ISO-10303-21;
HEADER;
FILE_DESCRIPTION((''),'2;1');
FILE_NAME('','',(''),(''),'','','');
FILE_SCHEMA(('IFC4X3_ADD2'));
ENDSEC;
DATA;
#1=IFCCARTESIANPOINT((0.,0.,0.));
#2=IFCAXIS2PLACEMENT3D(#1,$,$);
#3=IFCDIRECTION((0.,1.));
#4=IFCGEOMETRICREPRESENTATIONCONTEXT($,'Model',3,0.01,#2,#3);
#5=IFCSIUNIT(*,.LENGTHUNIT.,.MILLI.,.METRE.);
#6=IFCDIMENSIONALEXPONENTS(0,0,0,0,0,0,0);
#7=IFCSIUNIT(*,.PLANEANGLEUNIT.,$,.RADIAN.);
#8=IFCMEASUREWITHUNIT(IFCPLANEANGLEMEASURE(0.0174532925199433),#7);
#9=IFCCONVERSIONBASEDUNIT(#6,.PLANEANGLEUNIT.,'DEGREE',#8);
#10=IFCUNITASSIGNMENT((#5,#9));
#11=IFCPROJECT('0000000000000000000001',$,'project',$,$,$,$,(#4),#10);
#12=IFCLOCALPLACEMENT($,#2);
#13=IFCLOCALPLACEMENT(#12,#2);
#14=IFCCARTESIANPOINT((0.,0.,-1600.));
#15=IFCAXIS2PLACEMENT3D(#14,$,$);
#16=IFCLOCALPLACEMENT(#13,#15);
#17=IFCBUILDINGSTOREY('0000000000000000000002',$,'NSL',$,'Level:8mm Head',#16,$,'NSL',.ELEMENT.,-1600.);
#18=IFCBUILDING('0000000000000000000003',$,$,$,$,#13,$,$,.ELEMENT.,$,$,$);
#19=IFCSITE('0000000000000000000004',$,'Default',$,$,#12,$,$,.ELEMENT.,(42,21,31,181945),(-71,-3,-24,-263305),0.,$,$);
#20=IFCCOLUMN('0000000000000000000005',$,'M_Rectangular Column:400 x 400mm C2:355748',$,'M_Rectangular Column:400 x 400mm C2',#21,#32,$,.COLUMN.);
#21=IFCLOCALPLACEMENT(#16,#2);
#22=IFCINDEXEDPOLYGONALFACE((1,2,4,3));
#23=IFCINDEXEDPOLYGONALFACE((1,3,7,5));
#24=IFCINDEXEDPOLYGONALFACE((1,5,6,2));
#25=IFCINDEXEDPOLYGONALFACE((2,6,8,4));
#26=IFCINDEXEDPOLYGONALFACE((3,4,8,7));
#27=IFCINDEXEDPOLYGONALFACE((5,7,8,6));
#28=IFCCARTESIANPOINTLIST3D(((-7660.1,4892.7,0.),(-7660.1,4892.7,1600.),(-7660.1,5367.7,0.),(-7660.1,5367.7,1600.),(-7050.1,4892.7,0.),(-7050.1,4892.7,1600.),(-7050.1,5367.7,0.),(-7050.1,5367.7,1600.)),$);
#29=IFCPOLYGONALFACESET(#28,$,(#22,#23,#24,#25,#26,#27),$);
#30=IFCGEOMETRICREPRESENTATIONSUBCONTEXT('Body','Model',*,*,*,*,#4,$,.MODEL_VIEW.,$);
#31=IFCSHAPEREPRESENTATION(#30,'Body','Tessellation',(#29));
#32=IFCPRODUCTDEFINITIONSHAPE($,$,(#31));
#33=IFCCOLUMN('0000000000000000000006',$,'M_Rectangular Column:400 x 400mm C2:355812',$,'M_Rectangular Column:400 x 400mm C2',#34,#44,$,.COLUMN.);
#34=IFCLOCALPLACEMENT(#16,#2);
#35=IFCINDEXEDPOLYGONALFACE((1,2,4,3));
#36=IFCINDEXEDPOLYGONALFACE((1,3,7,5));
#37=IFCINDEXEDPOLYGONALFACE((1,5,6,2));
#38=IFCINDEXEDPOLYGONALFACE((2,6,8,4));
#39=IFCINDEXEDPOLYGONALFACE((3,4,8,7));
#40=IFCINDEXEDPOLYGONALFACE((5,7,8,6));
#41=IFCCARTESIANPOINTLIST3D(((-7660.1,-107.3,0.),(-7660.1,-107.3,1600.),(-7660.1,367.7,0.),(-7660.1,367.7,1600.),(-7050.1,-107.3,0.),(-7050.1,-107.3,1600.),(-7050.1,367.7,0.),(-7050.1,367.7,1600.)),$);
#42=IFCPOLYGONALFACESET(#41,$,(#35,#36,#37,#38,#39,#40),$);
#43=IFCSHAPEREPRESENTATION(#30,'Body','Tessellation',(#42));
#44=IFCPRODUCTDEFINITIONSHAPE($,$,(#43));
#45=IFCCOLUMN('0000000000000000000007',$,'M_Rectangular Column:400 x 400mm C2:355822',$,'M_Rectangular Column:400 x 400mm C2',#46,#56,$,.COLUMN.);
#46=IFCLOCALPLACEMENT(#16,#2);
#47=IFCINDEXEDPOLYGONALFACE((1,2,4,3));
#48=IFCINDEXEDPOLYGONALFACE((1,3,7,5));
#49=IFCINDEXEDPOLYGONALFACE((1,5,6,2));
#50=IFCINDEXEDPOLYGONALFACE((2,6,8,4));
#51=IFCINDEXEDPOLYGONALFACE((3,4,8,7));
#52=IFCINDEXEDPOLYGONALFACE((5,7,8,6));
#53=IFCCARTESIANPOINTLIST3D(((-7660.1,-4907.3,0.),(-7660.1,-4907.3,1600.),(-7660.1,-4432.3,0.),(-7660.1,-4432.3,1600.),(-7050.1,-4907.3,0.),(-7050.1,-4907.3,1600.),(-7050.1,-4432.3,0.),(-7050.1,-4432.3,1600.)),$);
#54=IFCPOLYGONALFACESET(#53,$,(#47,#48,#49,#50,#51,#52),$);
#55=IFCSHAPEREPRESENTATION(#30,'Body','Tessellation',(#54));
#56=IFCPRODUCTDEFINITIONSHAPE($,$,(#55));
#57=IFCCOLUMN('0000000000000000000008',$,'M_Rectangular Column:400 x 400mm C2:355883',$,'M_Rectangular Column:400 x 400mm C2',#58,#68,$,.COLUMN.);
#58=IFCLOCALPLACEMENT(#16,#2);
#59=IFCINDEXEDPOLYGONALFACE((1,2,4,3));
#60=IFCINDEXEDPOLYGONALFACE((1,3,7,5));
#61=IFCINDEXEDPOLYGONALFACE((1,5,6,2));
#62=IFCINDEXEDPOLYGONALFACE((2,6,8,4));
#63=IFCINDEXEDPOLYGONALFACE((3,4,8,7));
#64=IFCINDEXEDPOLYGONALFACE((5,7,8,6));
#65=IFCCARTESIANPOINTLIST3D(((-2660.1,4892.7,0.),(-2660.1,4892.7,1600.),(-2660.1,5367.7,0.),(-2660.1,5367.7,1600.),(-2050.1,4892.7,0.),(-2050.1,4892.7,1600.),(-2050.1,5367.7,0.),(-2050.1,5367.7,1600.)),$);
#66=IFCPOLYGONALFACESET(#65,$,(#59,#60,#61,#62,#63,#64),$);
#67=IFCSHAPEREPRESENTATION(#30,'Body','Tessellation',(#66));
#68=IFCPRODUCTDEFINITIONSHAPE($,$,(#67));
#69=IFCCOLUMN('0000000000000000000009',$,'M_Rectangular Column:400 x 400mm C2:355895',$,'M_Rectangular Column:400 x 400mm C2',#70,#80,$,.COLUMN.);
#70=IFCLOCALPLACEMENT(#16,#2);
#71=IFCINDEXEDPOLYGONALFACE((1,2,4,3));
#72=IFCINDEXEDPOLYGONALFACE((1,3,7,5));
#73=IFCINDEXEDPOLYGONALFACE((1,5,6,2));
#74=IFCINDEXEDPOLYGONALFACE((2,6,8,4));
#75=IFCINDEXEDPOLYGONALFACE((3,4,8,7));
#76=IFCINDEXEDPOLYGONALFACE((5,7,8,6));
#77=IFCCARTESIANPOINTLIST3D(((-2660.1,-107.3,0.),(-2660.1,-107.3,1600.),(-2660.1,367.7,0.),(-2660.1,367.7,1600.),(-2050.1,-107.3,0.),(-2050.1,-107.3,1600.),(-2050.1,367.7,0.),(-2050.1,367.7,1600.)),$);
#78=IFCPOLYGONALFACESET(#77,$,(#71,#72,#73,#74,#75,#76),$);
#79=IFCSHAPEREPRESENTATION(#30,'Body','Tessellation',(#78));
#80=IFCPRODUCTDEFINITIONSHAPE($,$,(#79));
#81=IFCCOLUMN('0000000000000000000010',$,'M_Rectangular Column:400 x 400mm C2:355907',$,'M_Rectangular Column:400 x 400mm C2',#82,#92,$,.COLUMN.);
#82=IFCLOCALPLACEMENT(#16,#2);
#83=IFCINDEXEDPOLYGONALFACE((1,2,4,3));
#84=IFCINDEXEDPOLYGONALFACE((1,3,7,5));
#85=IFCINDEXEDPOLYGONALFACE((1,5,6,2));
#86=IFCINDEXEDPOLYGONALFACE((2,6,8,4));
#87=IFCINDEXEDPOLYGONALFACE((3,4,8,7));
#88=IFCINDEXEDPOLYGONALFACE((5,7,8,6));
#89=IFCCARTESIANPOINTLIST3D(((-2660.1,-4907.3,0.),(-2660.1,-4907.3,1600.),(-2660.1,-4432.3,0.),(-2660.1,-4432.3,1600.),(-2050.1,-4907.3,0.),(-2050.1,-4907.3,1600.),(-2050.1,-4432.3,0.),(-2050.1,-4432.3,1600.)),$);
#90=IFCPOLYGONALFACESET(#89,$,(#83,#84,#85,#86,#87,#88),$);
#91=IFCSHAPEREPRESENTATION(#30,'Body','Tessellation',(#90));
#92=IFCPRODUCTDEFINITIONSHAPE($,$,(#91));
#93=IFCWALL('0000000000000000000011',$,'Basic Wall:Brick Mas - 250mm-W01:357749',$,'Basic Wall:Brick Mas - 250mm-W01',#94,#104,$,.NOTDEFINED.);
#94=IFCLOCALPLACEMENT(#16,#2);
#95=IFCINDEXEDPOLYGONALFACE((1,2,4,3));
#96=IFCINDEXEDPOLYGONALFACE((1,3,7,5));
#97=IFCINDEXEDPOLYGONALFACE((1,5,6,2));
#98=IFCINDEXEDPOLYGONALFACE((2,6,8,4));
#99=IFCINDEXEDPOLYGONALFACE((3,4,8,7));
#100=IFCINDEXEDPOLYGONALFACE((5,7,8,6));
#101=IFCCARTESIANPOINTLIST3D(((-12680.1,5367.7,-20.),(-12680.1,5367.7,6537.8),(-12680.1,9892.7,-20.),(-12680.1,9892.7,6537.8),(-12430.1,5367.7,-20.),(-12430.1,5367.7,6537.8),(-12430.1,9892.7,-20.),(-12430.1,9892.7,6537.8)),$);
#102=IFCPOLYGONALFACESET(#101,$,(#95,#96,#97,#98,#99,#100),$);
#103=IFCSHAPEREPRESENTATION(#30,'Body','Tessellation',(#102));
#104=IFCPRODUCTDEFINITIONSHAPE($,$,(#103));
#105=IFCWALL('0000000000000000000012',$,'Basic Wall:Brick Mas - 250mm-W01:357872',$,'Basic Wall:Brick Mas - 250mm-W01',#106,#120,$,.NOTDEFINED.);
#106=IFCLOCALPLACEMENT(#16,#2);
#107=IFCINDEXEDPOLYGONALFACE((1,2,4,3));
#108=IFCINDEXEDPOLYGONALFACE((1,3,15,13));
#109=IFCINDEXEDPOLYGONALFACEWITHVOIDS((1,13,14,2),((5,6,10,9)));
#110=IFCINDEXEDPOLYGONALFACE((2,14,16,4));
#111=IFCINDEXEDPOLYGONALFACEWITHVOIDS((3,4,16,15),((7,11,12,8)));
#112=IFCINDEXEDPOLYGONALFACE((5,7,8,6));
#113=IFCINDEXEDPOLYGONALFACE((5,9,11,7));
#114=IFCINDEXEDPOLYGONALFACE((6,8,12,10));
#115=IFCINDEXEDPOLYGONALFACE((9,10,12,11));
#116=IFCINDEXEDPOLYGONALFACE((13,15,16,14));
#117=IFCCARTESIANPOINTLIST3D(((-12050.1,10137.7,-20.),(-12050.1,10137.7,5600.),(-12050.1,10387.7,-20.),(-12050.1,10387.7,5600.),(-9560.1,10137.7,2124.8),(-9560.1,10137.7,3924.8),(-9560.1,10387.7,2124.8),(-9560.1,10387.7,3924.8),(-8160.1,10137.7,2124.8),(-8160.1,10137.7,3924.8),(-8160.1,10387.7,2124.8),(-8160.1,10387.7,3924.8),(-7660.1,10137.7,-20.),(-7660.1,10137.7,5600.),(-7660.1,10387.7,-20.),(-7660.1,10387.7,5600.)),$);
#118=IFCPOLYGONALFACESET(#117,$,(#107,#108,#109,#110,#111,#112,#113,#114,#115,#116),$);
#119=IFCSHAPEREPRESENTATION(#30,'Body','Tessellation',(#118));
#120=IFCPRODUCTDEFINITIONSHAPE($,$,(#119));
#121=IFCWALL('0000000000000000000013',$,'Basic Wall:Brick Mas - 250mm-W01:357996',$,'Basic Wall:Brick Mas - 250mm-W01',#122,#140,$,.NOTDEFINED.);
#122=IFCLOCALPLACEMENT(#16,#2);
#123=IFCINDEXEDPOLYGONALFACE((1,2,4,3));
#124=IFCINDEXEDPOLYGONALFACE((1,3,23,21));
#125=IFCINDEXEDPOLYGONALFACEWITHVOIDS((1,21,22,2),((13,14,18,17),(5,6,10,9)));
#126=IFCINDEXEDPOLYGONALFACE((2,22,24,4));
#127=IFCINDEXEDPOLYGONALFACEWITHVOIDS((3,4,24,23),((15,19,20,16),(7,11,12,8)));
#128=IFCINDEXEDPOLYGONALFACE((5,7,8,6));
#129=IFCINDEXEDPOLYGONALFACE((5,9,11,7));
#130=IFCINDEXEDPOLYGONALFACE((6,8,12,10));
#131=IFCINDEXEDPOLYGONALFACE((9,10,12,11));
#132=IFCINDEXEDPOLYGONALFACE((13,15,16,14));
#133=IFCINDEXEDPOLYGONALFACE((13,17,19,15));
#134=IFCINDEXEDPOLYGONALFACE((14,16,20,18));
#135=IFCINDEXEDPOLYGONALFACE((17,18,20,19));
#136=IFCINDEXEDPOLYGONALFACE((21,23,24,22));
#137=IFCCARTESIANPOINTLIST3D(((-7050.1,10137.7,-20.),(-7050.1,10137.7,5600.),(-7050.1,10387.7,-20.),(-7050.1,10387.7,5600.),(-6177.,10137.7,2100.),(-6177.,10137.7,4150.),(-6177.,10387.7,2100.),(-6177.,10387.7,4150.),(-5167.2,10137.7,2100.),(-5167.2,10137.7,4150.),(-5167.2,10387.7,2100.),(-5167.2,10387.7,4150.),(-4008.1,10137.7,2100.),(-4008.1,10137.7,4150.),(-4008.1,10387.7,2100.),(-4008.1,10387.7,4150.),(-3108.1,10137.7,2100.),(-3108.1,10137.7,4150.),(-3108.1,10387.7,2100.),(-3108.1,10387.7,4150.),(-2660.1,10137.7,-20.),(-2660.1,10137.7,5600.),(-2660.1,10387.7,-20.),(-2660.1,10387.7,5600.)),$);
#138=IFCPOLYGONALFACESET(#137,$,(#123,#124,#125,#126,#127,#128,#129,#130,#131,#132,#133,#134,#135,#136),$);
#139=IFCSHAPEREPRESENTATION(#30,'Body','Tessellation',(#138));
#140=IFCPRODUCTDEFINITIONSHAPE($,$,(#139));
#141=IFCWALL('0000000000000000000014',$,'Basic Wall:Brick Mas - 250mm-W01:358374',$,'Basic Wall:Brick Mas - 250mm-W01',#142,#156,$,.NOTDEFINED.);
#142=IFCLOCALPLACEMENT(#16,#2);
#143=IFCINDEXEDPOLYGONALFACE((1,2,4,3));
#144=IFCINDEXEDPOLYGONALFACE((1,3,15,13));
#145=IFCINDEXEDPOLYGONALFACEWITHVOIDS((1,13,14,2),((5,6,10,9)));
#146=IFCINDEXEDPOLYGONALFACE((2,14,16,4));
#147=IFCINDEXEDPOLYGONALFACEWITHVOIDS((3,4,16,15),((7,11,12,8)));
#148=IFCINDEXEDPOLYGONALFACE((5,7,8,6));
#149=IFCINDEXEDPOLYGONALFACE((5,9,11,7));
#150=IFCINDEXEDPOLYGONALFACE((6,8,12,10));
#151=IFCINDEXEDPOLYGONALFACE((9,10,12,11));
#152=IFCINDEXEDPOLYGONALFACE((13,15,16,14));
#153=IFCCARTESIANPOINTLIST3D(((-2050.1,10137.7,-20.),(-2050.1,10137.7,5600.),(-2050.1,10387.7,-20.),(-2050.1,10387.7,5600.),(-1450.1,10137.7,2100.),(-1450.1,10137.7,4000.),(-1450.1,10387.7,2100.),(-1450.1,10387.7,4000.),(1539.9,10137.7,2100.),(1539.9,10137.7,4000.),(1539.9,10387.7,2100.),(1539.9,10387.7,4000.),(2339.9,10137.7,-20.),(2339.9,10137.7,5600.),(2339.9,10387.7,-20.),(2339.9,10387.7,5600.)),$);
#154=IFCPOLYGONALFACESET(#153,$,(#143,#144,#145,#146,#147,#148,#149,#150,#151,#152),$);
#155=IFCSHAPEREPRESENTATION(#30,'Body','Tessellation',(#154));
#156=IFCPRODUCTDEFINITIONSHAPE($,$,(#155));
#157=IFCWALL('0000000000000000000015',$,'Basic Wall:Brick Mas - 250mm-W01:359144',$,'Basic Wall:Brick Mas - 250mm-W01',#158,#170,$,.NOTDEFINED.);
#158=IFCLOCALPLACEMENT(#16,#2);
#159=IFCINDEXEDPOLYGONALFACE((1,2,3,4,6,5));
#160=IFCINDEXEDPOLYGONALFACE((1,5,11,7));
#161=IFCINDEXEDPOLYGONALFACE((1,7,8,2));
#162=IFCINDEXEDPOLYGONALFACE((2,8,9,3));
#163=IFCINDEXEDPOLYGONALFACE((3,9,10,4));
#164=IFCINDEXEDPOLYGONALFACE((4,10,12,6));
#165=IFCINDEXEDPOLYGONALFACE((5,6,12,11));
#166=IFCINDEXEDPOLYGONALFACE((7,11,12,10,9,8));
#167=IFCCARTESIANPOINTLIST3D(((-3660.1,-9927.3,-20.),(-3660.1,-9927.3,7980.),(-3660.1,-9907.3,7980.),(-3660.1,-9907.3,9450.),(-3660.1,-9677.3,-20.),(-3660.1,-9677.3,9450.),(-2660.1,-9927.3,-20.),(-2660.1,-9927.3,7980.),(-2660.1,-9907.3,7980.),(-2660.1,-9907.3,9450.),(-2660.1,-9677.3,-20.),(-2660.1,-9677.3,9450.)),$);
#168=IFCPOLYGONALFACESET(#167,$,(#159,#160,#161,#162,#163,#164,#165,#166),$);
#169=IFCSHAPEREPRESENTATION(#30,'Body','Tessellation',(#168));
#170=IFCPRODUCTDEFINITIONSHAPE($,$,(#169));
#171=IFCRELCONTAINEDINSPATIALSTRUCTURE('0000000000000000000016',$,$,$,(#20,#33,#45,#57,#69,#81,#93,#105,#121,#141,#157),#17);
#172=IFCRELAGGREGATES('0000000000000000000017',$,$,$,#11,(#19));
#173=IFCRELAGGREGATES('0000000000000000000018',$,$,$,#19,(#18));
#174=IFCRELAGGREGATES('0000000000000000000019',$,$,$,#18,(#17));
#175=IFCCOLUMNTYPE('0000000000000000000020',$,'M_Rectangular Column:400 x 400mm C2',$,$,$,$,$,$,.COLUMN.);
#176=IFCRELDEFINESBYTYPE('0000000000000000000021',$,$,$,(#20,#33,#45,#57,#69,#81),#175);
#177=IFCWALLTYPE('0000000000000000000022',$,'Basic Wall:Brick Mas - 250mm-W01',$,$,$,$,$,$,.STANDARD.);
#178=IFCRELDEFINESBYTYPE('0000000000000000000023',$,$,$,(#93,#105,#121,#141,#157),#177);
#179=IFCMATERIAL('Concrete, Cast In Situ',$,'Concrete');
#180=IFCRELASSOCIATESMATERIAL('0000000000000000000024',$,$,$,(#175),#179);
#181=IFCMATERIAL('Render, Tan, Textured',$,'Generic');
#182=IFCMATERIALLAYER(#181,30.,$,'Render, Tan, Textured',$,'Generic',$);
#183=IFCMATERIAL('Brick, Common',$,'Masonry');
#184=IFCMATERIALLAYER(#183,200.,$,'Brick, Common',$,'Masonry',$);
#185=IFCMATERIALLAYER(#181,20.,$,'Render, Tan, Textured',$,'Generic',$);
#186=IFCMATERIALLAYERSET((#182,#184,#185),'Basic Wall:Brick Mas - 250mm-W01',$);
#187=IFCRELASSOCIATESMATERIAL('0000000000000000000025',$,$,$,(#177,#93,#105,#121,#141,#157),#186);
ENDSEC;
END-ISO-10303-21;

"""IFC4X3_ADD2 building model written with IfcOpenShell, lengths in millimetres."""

from ifc_helpers import new_model, entity, si_unit, converted_unit, direction, frame, frame_2d, origin, origin_2d_with_axis, place, context, subcontext, project, spatial, polyline, rectangle, extrude, clip, bounded_halfspace, source, transform, mapped, material, layer, layer_set, material_profile, profile_set, type_object, type_shapes, element, save


model = new_model("IFC4X3_ADD2")

# Units and contexts
model_context = context("Model", 3, precision=0.01, world=origin(), true_north=direction((0.0, 1.0)))
body_context = subcontext(model_context, "Body", "Model", "MODEL_VIEW")
ifc_project = project(units=[si_unit("LENGTHUNIT", "METRE", prefix="MILLI"), converted_unit("PLANEANGLEUNIT", "DEGREE", entity("IfcPlaneAngleMeasure", 0.0174532925199433), si_unit("PLANEANGLEUNIT", "RADIAN"), dimensions=[0, 0, 0, 0, 0, 0, 0])], contexts=[model_context])

# Site, building, storey
site_placement = place(None, origin())
site = spatial("IfcSite", under=ifc_project, at=site_placement, Name="Default", CompositionType="ELEMENT", RefLatitude=(42, 21, 31, 181945), RefLongitude=(-71, -3, -24, -263305), RefElevation=0.0)
building_placement = place(site_placement, origin())
building = spatial("IfcBuilding", under=site, at=building_placement, CompositionType="ELEMENT")
storey_placement = place(building_placement, frame((0.0, 0.0, -1600.0)))
storey = spatial("IfcBuildingStorey", under=building, at=storey_placement, Name="NSL", ObjectType="Level:8mm Head", LongName="NSL", CompositionType="ELEMENT", Elevation=-1600.0)

# Columns
ifc_material_1 = material(Name="Concrete, Cast In Situ", Category="Concrete")
ifc_material_profile_1 = material_profile(ifc_material_1, rectangle(XDim=610.0, YDim=475.0, at=origin_2d_with_axis()), Name="400 x 400mm C2")
ifc_profile_set_1 = profile_set([ifc_material_profile_1], Name="400 x 400mm C2")
column_type_1 = type_object("IfcColumnType", Name="M_Rectangular Column:400 x 400mm C2", PredefinedType="COLUMN", material=ifc_profile_set_1)
shared_shape_1 = source(origin(), body_context, "Body", "SweptSolid", [
    extrude(rectangle(XDim=610.0, YDim=475.0, at=origin_2d_with_axis()), frame((0.0, 0.0, -1600.0), z_axis=(0.0, 0.0, 1.0), x_axis=(-1.0, 0.0, 0.0)), (0.0, 0.0, 1.0), 1600.0),
])
type_shapes(column_type_1, [shared_shape_1])
for number, where, name in (
    (1, (-7355.1, 5130.2, 1600.0), "M_Rectangular Column:400 x 400mm C2:355748"),
    (2, (-7355.1, 130.2, 1600.0), "M_Rectangular Column:400 x 400mm C2:355812"),
    (3, (-7355.1, -4669.8, 1600.0), "M_Rectangular Column:400 x 400mm C2:355822"),
    (4, (-2355.1, 5130.2, 1600.0), "M_Rectangular Column:400 x 400mm C2:355883"),
    (5, (-2355.1, 130.2, 1600.0), "M_Rectangular Column:400 x 400mm C2:355895"),
    (6, (-2355.1, -4669.8, 1600.0), "M_Rectangular Column:400 x 400mm C2:355907"),
):
    element("IfcColumn", number, at=place(storey_placement, frame(where)), inside=storey, type_object=column_type_1, Name=name, ObjectType="M_Rectangular Column:400 x 400mm C2", PredefinedType="COLUMN", context=body_context, shape_type="MappedRepresentation", body=[
        mapped(shared_shape_1, transform((0.0, 0.0, 0.0), scale=1.0)),
    ])

# Wall
ifc_material_2 = material(Name="Render, Tan, Textured", Category="Generic")
ifc_layer_1 = layer(ifc_material_2, 30.0, Name="Render, Tan, Textured", Category="Generic")
ifc_material_3 = material(Name="Brick, Common", Category="Masonry")
ifc_layer_2 = layer(ifc_material_3, 200.0, Name="Brick, Common", Category="Masonry")
ifc_layer_3 = layer(ifc_material_2, 20.0, Name="Render, Tan, Textured", Category="Generic")
ifc_layer_set = layer_set([ifc_layer_1, ifc_layer_2, ifc_layer_3], Name="Basic Wall:Brick Mas - 250mm-W01")
wall_type = type_object("IfcWallType", Name="Basic Wall:Brick Mas - 250mm-W01", PredefinedType="STANDARD", material=ifc_layer_set)
wall_1_placement = place(storey_placement, frame((-12555.1, 9892.7, -20.0), z_axis=(0.0, 0.0, 1.0), x_axis=(0.0, -1.0, 0.0)))
element("IfcWall", 7, at=wall_1_placement, inside=storey, type_object=wall_type, material=ifc_layer_set, Name="Basic Wall:Brick Mas - 250mm-W01:357749", ObjectType="Basic Wall:Brick Mas - 250mm-W01", PredefinedType="NOTDEFINED", context=body_context, shape_type="SweptSolid", body=[
    extrude(rectangle(XDim=4525.0, YDim=250.0, at=frame_2d((2262.5, 0.0), x_axis=(-1.0, 0.0))), origin(), (0.0, 0.0, 1.0), 6557.8),
])

# Wall, opening
wall_2_placement = place(storey_placement, frame((-12050.1, 10262.7, -20.0)))
wall_2 = element("IfcWall", 8, at=wall_2_placement, inside=storey, type_object=wall_type, material=ifc_layer_set, Name="Basic Wall:Brick Mas - 250mm-W01:357872", ObjectType="Basic Wall:Brick Mas - 250mm-W01", PredefinedType="NOTDEFINED", context=body_context, shape_type="SweptSolid", body=[
    extrude(rectangle(XDim=4390.0, YDim=250.0, at=frame_2d((2195.0, 0.0), x_axis=(-1.0, 0.0))), origin(), (0.0, 0.0, 1.0), 5620.0),
])
opening_1_placement = place(wall_2_placement, frame((2490.0, -125.0, 2144.8)))
element("IfcOpeningElement", 9, at=opening_1_placement, cuts=wall_2, PredefinedType="OPENING", context=body_context, shape_type="SweptSolid", body=[
    extrude(rectangle(XDim=1800.0, YDim=1400.0, at=frame_2d((900.0, 700.0), x_axis=(-1.0, 0.0))), frame((0.0, 0.0, 0.0), z_axis=(0.0, 1.0, 0.0), x_axis=(0.0, 0.0, 1.0)), (0.0, 0.0, 1.0), 250.0),
])

# Wall, openings
wall_3_placement = place(storey_placement, frame((-7050.1, 10262.7, -20.0)))
wall_3 = element("IfcWall", 10, at=wall_3_placement, inside=storey, type_object=wall_type, material=ifc_layer_set, Name="Basic Wall:Brick Mas - 250mm-W01:357996", ObjectType="Basic Wall:Brick Mas - 250mm-W01", PredefinedType="NOTDEFINED", context=body_context, shape_type="SweptSolid", body=[
    extrude(rectangle(XDim=4390.0, YDim=250.0, at=frame_2d((2195.0, 0.0), x_axis=(-1.0, 0.0))), origin(), (0.0, 0.0, 1.0), 5620.0),
])
opening_2_placement = place(wall_3_placement, origin())
element("IfcOpeningElement", 11, at=opening_2_placement, cuts=wall_3, PredefinedType="OPENING", context=body_context, shape_type="SweptSolid", body=[
    extrude(rectangle(XDim=2050.0, YDim=900.0, at=frame_2d((0.0, 0.0), x_axis=(0.0, 1.0))), frame((3492.0, 125.0, 3145.0), z_axis=(0.0, -1.0, 0.0), x_axis=(1.0, 0.0, 0.0)), (0.0, 0.0, 1.0), 250.0),
])
opening_3_placement = place(wall_3_placement, origin())
element("IfcOpeningElement", 12, at=opening_3_placement, cuts=wall_3, PredefinedType="OPENING", context=body_context, shape_type="SweptSolid", body=[
    extrude(rectangle(XDim=2050.0, YDim=1009.8, at=frame_2d((0.0, 0.0), x_axis=(0.0, 1.0))), frame((1378.0, 125.0, 3145.0), z_axis=(0.0, -1.0, 0.0), x_axis=(1.0, 0.0, 0.0)), (0.0, 0.0, 1.0), 250.0),
])

# Wall, opening
wall_4_placement = place(storey_placement, frame((-2050.1, 10262.7, -20.0)))
wall_4 = element("IfcWall", 13, at=wall_4_placement, inside=storey, type_object=wall_type, material=ifc_layer_set, Name="Basic Wall:Brick Mas - 250mm-W01:358374", ObjectType="Basic Wall:Brick Mas - 250mm-W01", PredefinedType="NOTDEFINED", context=body_context, shape_type="SweptSolid", body=[
    extrude(rectangle(XDim=4390.0, YDim=250.0, at=frame_2d((2195.0, 0.0), x_axis=(-1.0, 0.0))), origin(), (0.0, 0.0, 1.0), 5620.0),
])
opening_4_placement = place(wall_4_placement, origin())
element("IfcOpeningElement", 14, at=opening_4_placement, cuts=wall_4, PredefinedType="OPENING", context=body_context, shape_type="SweptSolid", body=[
    extrude(rectangle(XDim=1900.0, YDim=2990.0, at=frame_2d((0.0, 0.0), x_axis=(0.0, 1.0))), frame((2095.0, 125.0, 3070.0), z_axis=(0.0, -1.0, 0.0), x_axis=(1.0, 0.0, 0.0)), (0.0, 0.0, 1.0), 250.0),
])

# Wall
wall_5_placement = place(storey_placement, frame((-2660.1, -9802.3, -20.0), z_axis=(0.0, 0.0, 1.0), x_axis=(-1.0, 0.0, 0.0)))
element("IfcWall", 15, at=wall_5_placement, inside=storey, type_object=wall_type, material=ifc_layer_set, Name="Basic Wall:Brick Mas - 250mm-W01:359144", ObjectType="Basic Wall:Brick Mas - 250mm-W01", PredefinedType="NOTDEFINED", context=body_context, shape_type="Clipping", body=[
    clip(clip(extrude(rectangle(XDim=1000.0, YDim=250.0, at=frame_2d((500.0, 0.0), x_axis=(-1.0, 0.0))), origin(), (0.0, 0.0, 1.0), 9470.0), bounded_halfspace(frame((0.0, -125.0, 9470.0), z_axis=(0.0, 0.0, -1.0), x_axis=(0.0, 1.0, 0.0)), True, frame((0.0, -125.0, 9470.0)), polyline([(0.0, 0.0), (1000.0, 0.0), (1000.0, 230.0), (0.0, 230.0), (0.0, 0.0)]))), bounded_halfspace(frame((1000.0, 105.0, 8000.0), z_axis=(0.0, 0.0, 1.0), x_axis=(0.0, 1.0, 0.0)), False, frame((1000.0, 105.0, 8000.0)), polyline([(0.0, 0.0), (0.0, 20.0), (-1000.0, 20.0), (-1000.0, 0.0), (0.0, 0.0)]))),
])

save(model, "model.ifc")
